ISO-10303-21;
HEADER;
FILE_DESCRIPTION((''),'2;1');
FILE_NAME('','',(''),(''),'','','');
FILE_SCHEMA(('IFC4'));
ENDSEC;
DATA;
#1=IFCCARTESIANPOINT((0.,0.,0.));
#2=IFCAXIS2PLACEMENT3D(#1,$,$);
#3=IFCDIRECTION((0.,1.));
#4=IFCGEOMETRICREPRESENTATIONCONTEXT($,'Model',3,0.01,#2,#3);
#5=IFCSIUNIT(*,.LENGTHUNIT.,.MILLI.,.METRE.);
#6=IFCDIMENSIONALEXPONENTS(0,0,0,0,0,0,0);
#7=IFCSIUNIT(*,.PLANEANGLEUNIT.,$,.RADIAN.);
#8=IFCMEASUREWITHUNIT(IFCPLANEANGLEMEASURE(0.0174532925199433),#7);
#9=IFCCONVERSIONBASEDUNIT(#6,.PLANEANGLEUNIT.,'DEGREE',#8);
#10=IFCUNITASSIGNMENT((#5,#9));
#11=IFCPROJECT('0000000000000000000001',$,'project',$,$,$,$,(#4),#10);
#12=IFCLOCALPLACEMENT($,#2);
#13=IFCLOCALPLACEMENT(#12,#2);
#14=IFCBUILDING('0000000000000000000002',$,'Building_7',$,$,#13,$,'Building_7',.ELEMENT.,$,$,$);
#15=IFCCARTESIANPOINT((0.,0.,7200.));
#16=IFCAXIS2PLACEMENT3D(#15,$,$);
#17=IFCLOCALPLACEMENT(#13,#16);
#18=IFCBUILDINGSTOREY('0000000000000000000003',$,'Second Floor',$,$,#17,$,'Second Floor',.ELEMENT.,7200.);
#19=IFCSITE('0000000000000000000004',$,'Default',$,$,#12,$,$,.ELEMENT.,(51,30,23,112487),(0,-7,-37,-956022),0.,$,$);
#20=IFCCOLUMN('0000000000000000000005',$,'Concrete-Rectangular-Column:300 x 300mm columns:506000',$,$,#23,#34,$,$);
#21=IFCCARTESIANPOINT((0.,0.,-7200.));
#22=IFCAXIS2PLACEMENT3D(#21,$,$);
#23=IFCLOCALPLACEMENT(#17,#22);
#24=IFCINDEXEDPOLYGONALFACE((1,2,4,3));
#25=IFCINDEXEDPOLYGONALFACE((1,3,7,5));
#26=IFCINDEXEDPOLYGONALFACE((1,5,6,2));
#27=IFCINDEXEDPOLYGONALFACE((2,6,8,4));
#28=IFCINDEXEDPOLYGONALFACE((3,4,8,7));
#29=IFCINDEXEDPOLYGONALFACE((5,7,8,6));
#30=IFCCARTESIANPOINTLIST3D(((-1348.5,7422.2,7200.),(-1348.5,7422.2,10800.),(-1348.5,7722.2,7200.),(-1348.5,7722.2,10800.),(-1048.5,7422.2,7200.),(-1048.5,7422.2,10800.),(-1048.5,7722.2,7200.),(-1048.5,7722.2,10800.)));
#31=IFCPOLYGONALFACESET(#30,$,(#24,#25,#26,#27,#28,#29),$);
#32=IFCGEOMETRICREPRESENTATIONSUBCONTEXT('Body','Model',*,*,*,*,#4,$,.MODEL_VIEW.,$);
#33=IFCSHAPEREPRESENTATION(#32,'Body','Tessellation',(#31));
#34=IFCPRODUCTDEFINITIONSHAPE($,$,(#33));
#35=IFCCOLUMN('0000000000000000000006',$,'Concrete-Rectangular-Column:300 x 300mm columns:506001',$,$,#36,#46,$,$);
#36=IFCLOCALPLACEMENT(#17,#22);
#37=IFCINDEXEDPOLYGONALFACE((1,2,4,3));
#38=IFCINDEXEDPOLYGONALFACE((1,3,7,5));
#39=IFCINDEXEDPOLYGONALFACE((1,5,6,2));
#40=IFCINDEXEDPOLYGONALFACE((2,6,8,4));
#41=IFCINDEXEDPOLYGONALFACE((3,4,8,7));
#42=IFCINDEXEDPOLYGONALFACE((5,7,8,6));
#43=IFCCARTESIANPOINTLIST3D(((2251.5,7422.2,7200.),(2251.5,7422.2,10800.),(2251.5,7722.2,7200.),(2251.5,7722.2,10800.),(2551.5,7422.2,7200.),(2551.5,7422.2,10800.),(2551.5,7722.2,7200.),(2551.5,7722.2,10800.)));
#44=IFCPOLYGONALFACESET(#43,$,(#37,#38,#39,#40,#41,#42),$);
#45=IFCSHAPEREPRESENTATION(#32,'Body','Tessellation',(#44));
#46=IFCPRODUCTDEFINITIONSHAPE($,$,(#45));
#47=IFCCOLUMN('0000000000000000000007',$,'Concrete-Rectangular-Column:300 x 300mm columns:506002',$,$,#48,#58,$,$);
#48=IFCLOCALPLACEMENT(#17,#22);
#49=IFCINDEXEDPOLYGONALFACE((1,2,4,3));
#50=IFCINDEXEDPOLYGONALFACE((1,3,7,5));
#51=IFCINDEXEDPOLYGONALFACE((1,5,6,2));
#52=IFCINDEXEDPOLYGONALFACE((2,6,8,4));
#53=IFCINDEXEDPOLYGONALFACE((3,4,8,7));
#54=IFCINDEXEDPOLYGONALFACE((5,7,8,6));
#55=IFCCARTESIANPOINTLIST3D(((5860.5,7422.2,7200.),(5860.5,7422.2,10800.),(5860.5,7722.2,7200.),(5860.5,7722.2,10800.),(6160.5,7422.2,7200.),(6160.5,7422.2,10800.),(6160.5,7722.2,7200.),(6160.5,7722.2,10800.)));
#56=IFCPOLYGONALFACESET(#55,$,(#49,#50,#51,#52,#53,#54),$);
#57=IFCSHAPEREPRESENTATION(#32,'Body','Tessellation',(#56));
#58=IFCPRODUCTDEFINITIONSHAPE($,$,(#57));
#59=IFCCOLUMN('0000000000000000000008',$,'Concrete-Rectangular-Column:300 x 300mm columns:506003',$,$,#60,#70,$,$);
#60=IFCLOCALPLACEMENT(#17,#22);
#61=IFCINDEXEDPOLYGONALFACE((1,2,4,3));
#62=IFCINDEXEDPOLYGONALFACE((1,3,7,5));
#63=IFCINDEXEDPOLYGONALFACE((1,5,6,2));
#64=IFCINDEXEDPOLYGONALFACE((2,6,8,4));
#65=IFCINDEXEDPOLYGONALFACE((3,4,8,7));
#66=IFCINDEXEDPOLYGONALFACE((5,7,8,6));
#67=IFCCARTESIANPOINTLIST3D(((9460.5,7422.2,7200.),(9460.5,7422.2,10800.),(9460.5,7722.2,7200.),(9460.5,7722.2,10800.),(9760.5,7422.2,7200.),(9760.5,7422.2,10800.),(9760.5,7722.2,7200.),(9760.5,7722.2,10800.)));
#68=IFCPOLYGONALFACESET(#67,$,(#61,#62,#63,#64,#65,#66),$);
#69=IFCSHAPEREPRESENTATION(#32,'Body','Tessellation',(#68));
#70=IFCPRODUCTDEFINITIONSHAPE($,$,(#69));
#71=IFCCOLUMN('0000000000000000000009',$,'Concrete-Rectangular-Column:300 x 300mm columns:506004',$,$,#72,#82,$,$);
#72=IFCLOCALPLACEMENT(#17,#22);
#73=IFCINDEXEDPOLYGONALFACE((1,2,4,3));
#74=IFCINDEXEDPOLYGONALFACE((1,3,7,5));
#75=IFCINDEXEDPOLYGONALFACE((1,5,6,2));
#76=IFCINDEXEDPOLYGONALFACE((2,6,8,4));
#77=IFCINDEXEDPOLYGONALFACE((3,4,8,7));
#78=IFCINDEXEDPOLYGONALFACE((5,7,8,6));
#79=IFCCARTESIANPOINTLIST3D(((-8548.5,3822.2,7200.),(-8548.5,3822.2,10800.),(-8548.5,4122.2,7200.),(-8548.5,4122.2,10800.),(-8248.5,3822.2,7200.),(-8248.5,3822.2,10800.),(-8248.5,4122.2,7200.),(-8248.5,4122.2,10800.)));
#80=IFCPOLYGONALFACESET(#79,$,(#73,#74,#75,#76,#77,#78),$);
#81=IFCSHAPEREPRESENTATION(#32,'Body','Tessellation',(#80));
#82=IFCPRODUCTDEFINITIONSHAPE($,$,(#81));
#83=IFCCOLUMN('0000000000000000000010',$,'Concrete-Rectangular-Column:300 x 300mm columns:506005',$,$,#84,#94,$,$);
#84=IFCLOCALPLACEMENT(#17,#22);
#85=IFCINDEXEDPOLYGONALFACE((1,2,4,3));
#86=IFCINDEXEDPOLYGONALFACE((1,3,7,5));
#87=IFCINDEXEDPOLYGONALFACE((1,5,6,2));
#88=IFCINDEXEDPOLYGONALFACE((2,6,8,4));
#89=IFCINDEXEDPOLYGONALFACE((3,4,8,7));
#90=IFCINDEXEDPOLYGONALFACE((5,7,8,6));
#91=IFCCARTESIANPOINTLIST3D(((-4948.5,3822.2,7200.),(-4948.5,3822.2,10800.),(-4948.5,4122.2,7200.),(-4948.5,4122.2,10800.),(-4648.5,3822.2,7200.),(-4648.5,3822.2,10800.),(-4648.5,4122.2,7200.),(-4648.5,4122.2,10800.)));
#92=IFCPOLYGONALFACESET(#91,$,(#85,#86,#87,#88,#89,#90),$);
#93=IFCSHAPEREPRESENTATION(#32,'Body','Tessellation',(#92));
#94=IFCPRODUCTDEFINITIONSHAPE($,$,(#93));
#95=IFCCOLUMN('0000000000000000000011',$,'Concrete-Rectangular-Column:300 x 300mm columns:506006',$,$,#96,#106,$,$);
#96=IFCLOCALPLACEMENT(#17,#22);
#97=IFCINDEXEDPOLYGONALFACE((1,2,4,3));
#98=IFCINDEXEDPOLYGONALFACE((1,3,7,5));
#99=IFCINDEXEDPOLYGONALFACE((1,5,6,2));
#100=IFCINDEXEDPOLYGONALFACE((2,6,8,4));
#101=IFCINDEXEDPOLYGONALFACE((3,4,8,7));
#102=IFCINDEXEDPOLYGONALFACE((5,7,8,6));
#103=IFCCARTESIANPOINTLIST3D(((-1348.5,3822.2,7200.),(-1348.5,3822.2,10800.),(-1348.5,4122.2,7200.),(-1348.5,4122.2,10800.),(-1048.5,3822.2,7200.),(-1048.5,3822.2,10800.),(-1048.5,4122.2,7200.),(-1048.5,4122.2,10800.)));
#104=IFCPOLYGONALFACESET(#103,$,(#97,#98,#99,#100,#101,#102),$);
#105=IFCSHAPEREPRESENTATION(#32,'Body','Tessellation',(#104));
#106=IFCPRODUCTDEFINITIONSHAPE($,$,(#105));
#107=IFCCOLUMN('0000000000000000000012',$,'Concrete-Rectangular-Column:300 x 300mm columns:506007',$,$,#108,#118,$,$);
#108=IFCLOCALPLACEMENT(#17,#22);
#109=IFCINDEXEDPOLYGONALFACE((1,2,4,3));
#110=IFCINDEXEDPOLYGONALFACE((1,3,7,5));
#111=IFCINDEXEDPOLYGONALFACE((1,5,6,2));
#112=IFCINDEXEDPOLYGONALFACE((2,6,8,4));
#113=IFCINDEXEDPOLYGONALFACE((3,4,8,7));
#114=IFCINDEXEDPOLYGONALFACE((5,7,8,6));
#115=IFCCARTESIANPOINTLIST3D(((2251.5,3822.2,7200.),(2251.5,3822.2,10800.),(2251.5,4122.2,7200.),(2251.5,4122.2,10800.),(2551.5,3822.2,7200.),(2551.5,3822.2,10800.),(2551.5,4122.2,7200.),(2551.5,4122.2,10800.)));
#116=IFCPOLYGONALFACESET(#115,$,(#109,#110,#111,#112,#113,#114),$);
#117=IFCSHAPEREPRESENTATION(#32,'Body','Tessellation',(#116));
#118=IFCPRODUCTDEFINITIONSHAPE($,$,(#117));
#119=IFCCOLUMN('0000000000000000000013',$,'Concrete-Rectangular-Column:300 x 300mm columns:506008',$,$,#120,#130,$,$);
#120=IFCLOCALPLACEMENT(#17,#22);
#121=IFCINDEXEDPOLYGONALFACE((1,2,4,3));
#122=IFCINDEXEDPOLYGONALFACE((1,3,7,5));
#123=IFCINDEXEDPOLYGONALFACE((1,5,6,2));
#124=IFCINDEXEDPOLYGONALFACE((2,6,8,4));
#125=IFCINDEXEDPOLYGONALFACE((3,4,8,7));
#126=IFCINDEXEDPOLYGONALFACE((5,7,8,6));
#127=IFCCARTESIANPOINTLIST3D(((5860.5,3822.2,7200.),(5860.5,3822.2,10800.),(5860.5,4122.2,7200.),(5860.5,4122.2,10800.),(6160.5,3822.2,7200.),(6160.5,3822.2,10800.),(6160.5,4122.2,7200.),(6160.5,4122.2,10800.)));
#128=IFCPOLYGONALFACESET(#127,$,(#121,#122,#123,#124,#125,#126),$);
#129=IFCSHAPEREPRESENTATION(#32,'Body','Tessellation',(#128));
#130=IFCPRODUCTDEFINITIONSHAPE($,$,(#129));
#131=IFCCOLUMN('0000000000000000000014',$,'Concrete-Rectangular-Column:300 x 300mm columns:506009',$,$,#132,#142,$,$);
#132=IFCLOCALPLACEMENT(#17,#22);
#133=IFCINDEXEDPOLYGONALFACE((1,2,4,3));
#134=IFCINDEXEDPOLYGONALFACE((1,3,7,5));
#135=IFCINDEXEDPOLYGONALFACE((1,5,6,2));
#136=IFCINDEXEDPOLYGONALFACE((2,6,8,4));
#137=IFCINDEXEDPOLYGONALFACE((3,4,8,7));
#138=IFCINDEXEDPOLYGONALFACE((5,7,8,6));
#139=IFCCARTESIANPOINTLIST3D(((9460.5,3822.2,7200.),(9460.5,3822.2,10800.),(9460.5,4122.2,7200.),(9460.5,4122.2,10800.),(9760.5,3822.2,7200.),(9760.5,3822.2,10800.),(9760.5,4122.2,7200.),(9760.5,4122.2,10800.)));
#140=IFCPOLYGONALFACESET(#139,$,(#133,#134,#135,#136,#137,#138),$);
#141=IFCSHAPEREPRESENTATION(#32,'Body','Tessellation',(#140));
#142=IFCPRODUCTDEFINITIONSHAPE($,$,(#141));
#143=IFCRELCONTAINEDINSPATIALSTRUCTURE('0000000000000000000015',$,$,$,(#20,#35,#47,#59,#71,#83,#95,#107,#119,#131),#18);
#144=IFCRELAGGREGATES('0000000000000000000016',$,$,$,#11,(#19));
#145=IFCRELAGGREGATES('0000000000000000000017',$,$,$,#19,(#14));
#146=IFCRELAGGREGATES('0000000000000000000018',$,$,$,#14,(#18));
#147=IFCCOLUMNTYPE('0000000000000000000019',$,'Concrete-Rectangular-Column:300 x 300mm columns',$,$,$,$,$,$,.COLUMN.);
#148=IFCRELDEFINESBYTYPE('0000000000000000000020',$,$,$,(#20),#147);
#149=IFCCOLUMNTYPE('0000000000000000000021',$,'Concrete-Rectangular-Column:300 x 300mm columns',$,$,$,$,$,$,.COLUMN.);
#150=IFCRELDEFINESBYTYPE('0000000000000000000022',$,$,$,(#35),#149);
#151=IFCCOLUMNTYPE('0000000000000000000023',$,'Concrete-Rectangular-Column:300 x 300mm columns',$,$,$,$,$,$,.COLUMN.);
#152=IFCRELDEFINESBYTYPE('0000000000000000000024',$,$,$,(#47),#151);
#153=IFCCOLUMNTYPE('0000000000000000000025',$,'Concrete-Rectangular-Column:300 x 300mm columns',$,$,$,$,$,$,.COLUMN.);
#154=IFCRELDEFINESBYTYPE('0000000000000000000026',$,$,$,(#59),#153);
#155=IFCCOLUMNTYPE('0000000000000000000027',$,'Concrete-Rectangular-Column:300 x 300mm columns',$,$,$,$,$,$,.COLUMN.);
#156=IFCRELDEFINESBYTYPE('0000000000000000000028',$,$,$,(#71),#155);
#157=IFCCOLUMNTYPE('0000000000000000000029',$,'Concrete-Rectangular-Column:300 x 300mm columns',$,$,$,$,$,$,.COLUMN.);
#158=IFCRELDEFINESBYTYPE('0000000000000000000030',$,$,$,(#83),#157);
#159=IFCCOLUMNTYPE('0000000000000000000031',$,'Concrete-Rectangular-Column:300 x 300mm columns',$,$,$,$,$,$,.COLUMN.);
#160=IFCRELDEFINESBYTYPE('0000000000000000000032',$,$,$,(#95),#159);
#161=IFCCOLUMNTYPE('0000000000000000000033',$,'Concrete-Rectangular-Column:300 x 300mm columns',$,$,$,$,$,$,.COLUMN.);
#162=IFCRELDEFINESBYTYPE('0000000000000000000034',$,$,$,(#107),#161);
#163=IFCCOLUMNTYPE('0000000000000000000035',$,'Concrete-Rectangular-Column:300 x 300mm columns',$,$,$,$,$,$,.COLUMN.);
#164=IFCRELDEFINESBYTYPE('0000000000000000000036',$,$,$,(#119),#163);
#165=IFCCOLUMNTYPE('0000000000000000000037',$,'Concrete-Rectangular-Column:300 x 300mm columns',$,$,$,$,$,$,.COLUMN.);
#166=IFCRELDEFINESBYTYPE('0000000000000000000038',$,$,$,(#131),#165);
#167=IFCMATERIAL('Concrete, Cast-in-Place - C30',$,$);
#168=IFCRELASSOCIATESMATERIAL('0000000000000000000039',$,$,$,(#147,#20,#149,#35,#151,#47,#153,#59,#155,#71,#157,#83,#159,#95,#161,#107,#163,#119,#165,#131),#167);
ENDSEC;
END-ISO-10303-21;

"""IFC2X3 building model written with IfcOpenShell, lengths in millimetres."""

from ifc_helpers import new_model, entity, si_unit, converted_unit, direction, frame, frame_2d, origin, origin_2d_with_axis, place, context, subcontext, project, spatial, rectangle, extrude, source, transform, mapped, material, type_object, type_shapes, element, save


model = new_model("IFC2X3")

# Units and contexts
model_context = context("Model", 3, precision=0.01, world=origin(), true_north=direction((0.0, 1.0)))
body_context = subcontext(model_context, "Body", "Model", "MODEL_VIEW")
ifc_project = project(units=[si_unit("LENGTHUNIT", "METRE", prefix="MILLI"), converted_unit("PLANEANGLEUNIT", "DEGREE", entity("IfcPlaneAngleMeasure", 0.0174532925199433), si_unit("PLANEANGLEUNIT", "RADIAN"), dimensions=[0, 0, 0, 0, 0, 0, 0])], contexts=[model_context])

# Site, building, storey
site_placement = place(None, origin())
site = spatial("IfcSite", under=ifc_project, at=site_placement, Name="Default", CompositionType="ELEMENT", RefLatitude=(51, 30, 23, 112487), RefLongitude=(0, -7, -37, -956022), RefElevation=0.0)
building_placement = place(site_placement, origin())
building = spatial("IfcBuilding", under=site, at=building_placement, Name="Building_7", LongName="Building_7", CompositionType="ELEMENT")
storey_placement = place(building_placement, frame((0.0, 0.0, 7200.0)))
storey = spatial("IfcBuildingStorey", under=building, at=storey_placement, Name="Second Floor", LongName="Second Floor", CompositionType="ELEMENT", Elevation=7200.0)

# Columns
ifc_material_1 = material(Name="Concrete, Cast-in-Place - C30")
column_type_1 = type_object("IfcColumnType", Name="Concrete-Rectangular-Column:300 x 300mm columns", PredefinedType="COLUMN", material=ifc_material_1)
shared_shape_1 = source(origin(), body_context, "Body", "SweptSolid", [
    extrude(rectangle(XDim=300.0, YDim=300.0, at=frame_2d((0.0, 0.0), x_axis=(1.0, 0.0))), frame((-1198.5, 7572.2, 7200.0), z_axis=(0.0, 0.0, 1.0), x_axis=(-1.0, 0.0, 0.0)), (0.0, 0.0, 1.0), 3600.0),
])
type_shapes(column_type_1, [shared_shape_1])
column_1_placement = place(storey_placement, frame((0.0, 0.0, -7200.0)))
element("IfcColumn", 1, at=column_1_placement, inside=storey, type_object=column_type_1, material=ifc_material_1, Name="Concrete-Rectangular-Column:300 x 300mm columns:506000", context=body_context, shape_type="MappedRepresentation", body=[
    mapped(shared_shape_1, transform((0.0, 0.0, 0.0), scale=1.0)),
])
column_type_2 = type_object("IfcColumnType", Name="Concrete-Rectangular-Column:300 x 300mm columns", PredefinedType="COLUMN", material=ifc_material_1)
shared_shape_2 = source(origin(), body_context, "Body", "SweptSolid", [
    extrude(rectangle(XDim=300.0, YDim=300.0, at=frame_2d((0.0, 0.0), x_axis=(1.0, 0.0))), frame((2401.5, 7572.2, 7200.0), z_axis=(0.0, 0.0, 1.0), x_axis=(-1.0, 0.0, 0.0)), (0.0, 0.0, 1.0), 3600.0),
])
type_shapes(column_type_2, [shared_shape_2])
column_2_placement = place(storey_placement, frame((0.0, 0.0, -7200.0)))
element("IfcColumn", 2, at=column_2_placement, inside=storey, type_object=column_type_2, material=ifc_material_1, Name="Concrete-Rectangular-Column:300 x 300mm columns:506001", context=body_context, shape_type="MappedRepresentation", body=[
    mapped(shared_shape_2, transform((0.0, 0.0, 0.0), scale=1.0)),
])
column_type_3 = type_object("IfcColumnType", Name="Concrete-Rectangular-Column:300 x 300mm columns", PredefinedType="COLUMN", material=ifc_material_1)
shared_shape_3 = source(origin(), body_context, "Body", "SweptSolid", [
    extrude(rectangle(XDim=300.0, YDim=300.0, at=frame_2d((0.0, 0.0), x_axis=(1.0, 0.0))), frame((6010.5, 7572.2, 7200.0), z_axis=(0.0, 0.0, 1.0), x_axis=(-1.0, 0.0, 0.0)), (0.0, 0.0, 1.0), 3600.0),
])
type_shapes(column_type_3, [shared_shape_3])
column_3_placement = place(storey_placement, frame((0.0, 0.0, -7200.0)))
element("IfcColumn", 3, at=column_3_placement, inside=storey, type_object=column_type_3, material=ifc_material_1, Name="Concrete-Rectangular-Column:300 x 300mm columns:506002", context=body_context, shape_type="MappedRepresentation", body=[
    mapped(shared_shape_3, transform((0.0, 0.0, 0.0), scale=1.0)),
])
column_type_4 = type_object("IfcColumnType", Name="Concrete-Rectangular-Column:300 x 300mm columns", PredefinedType="COLUMN", material=ifc_material_1)
shared_shape_4 = source(origin(), body_context, "Body", "SweptSolid", [
    extrude(rectangle(XDim=300.0, YDim=300.0, at=frame_2d((0.0, 0.0), x_axis=(1.0, 0.0))), frame((9610.5, 7572.2, 7200.0), z_axis=(0.0, 0.0, 1.0), x_axis=(-1.0, 0.0, 0.0)), (0.0, 0.0, 1.0), 3600.0),
])
type_shapes(column_type_4, [shared_shape_4])
column_4_placement = place(storey_placement, frame((0.0, 0.0, -7200.0)))
element("IfcColumn", 4, at=column_4_placement, inside=storey, type_object=column_type_4, material=ifc_material_1, Name="Concrete-Rectangular-Column:300 x 300mm columns:506003", context=body_context, shape_type="MappedRepresentation", body=[
    mapped(shared_shape_4, transform((0.0, 0.0, 0.0), scale=1.0)),
])
column_type_5 = type_object("IfcColumnType", Name="Concrete-Rectangular-Column:300 x 300mm columns", PredefinedType="COLUMN", material=ifc_material_1)
shared_shape_5 = source(origin(), body_context, "Body", "SweptSolid", [
    extrude(rectangle(XDim=300.0, YDim=300.0, at=frame_2d((0.0, 0.0), x_axis=(1.0, 0.0))), frame((-8398.5, 3972.2, 7200.0), z_axis=(0.0, 0.0, 1.0), x_axis=(-1.0, 0.0, 0.0)), (0.0, 0.0, 1.0), 3600.0),
])
type_shapes(column_type_5, [shared_shape_5])
column_5_placement = place(storey_placement, frame((0.0, 0.0, -7200.0)))
element("IfcColumn", 5, at=column_5_placement, inside=storey, type_object=column_type_5, material=ifc_material_1, Name="Concrete-Rectangular-Column:300 x 300mm columns:506004", context=body_context, shape_type="MappedRepresentation", body=[
    mapped(shared_shape_5, transform((0.0, 0.0, 0.0), scale=1.0)),
])
column_type_6 = type_object("IfcColumnType", Name="Concrete-Rectangular-Column:300 x 300mm columns", PredefinedType="COLUMN", material=ifc_material_1)
shared_shape_6 = source(origin(), body_context, "Body", "SweptSolid", [
    extrude(rectangle(XDim=300.0, YDim=300.0, at=frame_2d((0.0, 0.0), x_axis=(1.0, 0.0))), frame((-4798.5, 3972.2, 7200.0), z_axis=(0.0, 0.0, 1.0), x_axis=(-1.0, 0.0, 0.0)), (0.0, 0.0, 1.0), 3600.0),
])
type_shapes(column_type_6, [shared_shape_6])
column_6_placement = place(storey_placement, frame((0.0, 0.0, -7200.0)))
element("IfcColumn", 6, at=column_6_placement, inside=storey, type_object=column_type_6, material=ifc_material_1, Name="Concrete-Rectangular-Column:300 x 300mm columns:506005", context=body_context, shape_type="MappedRepresentation", body=[
    mapped(shared_shape_6, transform((0.0, 0.0, 0.0), scale=1.0)),
])
column_type_7 = type_object("IfcColumnType", Name="Concrete-Rectangular-Column:300 x 300mm columns", PredefinedType="COLUMN", material=ifc_material_1)
shared_shape_7 = source(origin(), body_context, "Body", "SweptSolid", [
    extrude(rectangle(XDim=300.0, YDim=300.0, at=origin_2d_with_axis()), frame((-1198.5, 3972.2, 7200.0), z_axis=(0.0, 0.0, 1.0), x_axis=(-1.0, 0.0, 0.0)), (0.0, 0.0, 1.0), 3600.0),
])
type_shapes(column_type_7, [shared_shape_7])
column_7_placement = place(storey_placement, frame((0.0, 0.0, -7200.0)))
element("IfcColumn", 7, at=column_7_placement, inside=storey, type_object=column_type_7, material=ifc_material_1, Name="Concrete-Rectangular-Column:300 x 300mm columns:506006", context=body_context, shape_type="MappedRepresentation", body=[
    mapped(shared_shape_7, transform((0.0, 0.0, 0.0), scale=1.0)),
])
column_type_8 = type_object("IfcColumnType", Name="Concrete-Rectangular-Column:300 x 300mm columns", PredefinedType="COLUMN", material=ifc_material_1)
shared_shape_8 = source(origin(), body_context, "Body", "SweptSolid", [
    extrude(rectangle(XDim=300.0, YDim=300.0, at=frame_2d((0.0, 0.0), x_axis=(1.0, 0.0))), frame((2401.5, 3972.2, 7200.0), z_axis=(0.0, 0.0, 1.0), x_axis=(-1.0, 0.0, 0.0)), (0.0, 0.0, 1.0), 3600.0),
])
type_shapes(column_type_8, [shared_shape_8])
column_8_placement = place(storey_placement, frame((0.0, 0.0, -7200.0)))
element("IfcColumn", 8, at=column_8_placement, inside=storey, type_object=column_type_8, material=ifc_material_1, Name="Concrete-Rectangular-Column:300 x 300mm columns:506007", context=body_context, shape_type="MappedRepresentation", body=[
    mapped(shared_shape_8, transform((0.0, 0.0, 0.0), scale=1.0)),
])
column_type_9 = type_object("IfcColumnType", Name="Concrete-Rectangular-Column:300 x 300mm columns", PredefinedType="COLUMN", material=ifc_material_1)
shared_shape_9 = source(origin(), body_context, "Body", "SweptSolid", [
    extrude(rectangle(XDim=300.0, YDim=300.0, at=frame_2d((0.0, 0.0), x_axis=(1.0, 0.0))), frame((6010.5, 3972.2, 7200.0), z_axis=(0.0, 0.0, 1.0), x_axis=(-1.0, 0.0, 0.0)), (0.0, 0.0, 1.0), 3600.0),
])
type_shapes(column_type_9, [shared_shape_9])
column_9_placement = place(storey_placement, frame((0.0, 0.0, -7200.0)))
element("IfcColumn", 9, at=column_9_placement, inside=storey, type_object=column_type_9, material=ifc_material_1, Name="Concrete-Rectangular-Column:300 x 300mm columns:506008", context=body_context, shape_type="MappedRepresentation", body=[
    mapped(shared_shape_9, transform((0.0, 0.0, 0.0), scale=1.0)),
])
column_type_10 = type_object("IfcColumnType", Name="Concrete-Rectangular-Column:300 x 300mm columns", PredefinedType="COLUMN", material=ifc_material_1)
shared_shape_10 = source(origin(), body_context, "Body", "SweptSolid", [
    extrude(rectangle(XDim=300.0, YDim=300.0, at=frame_2d((0.0, 0.0), x_axis=(1.0, 0.0))), frame((9610.5, 3972.2, 7200.0), z_axis=(0.0, 0.0, 1.0), x_axis=(-1.0, 0.0, 0.0)), (0.0, 0.0, 1.0), 3600.0),
])
type_shapes(column_type_10, [shared_shape_10])
column_10_placement = place(storey_placement, frame((0.0, 0.0, -7200.0)))
element("IfcColumn", 10, at=column_10_placement, inside=storey, type_object=column_type_10, material=ifc_material_1, Name="Concrete-Rectangular-Column:300 x 300mm columns:506009", context=body_context, shape_type="MappedRepresentation", body=[
    mapped(shared_shape_10, transform((0.0, 0.0, 0.0), scale=1.0)),
])

save(model, "model.ifc")
